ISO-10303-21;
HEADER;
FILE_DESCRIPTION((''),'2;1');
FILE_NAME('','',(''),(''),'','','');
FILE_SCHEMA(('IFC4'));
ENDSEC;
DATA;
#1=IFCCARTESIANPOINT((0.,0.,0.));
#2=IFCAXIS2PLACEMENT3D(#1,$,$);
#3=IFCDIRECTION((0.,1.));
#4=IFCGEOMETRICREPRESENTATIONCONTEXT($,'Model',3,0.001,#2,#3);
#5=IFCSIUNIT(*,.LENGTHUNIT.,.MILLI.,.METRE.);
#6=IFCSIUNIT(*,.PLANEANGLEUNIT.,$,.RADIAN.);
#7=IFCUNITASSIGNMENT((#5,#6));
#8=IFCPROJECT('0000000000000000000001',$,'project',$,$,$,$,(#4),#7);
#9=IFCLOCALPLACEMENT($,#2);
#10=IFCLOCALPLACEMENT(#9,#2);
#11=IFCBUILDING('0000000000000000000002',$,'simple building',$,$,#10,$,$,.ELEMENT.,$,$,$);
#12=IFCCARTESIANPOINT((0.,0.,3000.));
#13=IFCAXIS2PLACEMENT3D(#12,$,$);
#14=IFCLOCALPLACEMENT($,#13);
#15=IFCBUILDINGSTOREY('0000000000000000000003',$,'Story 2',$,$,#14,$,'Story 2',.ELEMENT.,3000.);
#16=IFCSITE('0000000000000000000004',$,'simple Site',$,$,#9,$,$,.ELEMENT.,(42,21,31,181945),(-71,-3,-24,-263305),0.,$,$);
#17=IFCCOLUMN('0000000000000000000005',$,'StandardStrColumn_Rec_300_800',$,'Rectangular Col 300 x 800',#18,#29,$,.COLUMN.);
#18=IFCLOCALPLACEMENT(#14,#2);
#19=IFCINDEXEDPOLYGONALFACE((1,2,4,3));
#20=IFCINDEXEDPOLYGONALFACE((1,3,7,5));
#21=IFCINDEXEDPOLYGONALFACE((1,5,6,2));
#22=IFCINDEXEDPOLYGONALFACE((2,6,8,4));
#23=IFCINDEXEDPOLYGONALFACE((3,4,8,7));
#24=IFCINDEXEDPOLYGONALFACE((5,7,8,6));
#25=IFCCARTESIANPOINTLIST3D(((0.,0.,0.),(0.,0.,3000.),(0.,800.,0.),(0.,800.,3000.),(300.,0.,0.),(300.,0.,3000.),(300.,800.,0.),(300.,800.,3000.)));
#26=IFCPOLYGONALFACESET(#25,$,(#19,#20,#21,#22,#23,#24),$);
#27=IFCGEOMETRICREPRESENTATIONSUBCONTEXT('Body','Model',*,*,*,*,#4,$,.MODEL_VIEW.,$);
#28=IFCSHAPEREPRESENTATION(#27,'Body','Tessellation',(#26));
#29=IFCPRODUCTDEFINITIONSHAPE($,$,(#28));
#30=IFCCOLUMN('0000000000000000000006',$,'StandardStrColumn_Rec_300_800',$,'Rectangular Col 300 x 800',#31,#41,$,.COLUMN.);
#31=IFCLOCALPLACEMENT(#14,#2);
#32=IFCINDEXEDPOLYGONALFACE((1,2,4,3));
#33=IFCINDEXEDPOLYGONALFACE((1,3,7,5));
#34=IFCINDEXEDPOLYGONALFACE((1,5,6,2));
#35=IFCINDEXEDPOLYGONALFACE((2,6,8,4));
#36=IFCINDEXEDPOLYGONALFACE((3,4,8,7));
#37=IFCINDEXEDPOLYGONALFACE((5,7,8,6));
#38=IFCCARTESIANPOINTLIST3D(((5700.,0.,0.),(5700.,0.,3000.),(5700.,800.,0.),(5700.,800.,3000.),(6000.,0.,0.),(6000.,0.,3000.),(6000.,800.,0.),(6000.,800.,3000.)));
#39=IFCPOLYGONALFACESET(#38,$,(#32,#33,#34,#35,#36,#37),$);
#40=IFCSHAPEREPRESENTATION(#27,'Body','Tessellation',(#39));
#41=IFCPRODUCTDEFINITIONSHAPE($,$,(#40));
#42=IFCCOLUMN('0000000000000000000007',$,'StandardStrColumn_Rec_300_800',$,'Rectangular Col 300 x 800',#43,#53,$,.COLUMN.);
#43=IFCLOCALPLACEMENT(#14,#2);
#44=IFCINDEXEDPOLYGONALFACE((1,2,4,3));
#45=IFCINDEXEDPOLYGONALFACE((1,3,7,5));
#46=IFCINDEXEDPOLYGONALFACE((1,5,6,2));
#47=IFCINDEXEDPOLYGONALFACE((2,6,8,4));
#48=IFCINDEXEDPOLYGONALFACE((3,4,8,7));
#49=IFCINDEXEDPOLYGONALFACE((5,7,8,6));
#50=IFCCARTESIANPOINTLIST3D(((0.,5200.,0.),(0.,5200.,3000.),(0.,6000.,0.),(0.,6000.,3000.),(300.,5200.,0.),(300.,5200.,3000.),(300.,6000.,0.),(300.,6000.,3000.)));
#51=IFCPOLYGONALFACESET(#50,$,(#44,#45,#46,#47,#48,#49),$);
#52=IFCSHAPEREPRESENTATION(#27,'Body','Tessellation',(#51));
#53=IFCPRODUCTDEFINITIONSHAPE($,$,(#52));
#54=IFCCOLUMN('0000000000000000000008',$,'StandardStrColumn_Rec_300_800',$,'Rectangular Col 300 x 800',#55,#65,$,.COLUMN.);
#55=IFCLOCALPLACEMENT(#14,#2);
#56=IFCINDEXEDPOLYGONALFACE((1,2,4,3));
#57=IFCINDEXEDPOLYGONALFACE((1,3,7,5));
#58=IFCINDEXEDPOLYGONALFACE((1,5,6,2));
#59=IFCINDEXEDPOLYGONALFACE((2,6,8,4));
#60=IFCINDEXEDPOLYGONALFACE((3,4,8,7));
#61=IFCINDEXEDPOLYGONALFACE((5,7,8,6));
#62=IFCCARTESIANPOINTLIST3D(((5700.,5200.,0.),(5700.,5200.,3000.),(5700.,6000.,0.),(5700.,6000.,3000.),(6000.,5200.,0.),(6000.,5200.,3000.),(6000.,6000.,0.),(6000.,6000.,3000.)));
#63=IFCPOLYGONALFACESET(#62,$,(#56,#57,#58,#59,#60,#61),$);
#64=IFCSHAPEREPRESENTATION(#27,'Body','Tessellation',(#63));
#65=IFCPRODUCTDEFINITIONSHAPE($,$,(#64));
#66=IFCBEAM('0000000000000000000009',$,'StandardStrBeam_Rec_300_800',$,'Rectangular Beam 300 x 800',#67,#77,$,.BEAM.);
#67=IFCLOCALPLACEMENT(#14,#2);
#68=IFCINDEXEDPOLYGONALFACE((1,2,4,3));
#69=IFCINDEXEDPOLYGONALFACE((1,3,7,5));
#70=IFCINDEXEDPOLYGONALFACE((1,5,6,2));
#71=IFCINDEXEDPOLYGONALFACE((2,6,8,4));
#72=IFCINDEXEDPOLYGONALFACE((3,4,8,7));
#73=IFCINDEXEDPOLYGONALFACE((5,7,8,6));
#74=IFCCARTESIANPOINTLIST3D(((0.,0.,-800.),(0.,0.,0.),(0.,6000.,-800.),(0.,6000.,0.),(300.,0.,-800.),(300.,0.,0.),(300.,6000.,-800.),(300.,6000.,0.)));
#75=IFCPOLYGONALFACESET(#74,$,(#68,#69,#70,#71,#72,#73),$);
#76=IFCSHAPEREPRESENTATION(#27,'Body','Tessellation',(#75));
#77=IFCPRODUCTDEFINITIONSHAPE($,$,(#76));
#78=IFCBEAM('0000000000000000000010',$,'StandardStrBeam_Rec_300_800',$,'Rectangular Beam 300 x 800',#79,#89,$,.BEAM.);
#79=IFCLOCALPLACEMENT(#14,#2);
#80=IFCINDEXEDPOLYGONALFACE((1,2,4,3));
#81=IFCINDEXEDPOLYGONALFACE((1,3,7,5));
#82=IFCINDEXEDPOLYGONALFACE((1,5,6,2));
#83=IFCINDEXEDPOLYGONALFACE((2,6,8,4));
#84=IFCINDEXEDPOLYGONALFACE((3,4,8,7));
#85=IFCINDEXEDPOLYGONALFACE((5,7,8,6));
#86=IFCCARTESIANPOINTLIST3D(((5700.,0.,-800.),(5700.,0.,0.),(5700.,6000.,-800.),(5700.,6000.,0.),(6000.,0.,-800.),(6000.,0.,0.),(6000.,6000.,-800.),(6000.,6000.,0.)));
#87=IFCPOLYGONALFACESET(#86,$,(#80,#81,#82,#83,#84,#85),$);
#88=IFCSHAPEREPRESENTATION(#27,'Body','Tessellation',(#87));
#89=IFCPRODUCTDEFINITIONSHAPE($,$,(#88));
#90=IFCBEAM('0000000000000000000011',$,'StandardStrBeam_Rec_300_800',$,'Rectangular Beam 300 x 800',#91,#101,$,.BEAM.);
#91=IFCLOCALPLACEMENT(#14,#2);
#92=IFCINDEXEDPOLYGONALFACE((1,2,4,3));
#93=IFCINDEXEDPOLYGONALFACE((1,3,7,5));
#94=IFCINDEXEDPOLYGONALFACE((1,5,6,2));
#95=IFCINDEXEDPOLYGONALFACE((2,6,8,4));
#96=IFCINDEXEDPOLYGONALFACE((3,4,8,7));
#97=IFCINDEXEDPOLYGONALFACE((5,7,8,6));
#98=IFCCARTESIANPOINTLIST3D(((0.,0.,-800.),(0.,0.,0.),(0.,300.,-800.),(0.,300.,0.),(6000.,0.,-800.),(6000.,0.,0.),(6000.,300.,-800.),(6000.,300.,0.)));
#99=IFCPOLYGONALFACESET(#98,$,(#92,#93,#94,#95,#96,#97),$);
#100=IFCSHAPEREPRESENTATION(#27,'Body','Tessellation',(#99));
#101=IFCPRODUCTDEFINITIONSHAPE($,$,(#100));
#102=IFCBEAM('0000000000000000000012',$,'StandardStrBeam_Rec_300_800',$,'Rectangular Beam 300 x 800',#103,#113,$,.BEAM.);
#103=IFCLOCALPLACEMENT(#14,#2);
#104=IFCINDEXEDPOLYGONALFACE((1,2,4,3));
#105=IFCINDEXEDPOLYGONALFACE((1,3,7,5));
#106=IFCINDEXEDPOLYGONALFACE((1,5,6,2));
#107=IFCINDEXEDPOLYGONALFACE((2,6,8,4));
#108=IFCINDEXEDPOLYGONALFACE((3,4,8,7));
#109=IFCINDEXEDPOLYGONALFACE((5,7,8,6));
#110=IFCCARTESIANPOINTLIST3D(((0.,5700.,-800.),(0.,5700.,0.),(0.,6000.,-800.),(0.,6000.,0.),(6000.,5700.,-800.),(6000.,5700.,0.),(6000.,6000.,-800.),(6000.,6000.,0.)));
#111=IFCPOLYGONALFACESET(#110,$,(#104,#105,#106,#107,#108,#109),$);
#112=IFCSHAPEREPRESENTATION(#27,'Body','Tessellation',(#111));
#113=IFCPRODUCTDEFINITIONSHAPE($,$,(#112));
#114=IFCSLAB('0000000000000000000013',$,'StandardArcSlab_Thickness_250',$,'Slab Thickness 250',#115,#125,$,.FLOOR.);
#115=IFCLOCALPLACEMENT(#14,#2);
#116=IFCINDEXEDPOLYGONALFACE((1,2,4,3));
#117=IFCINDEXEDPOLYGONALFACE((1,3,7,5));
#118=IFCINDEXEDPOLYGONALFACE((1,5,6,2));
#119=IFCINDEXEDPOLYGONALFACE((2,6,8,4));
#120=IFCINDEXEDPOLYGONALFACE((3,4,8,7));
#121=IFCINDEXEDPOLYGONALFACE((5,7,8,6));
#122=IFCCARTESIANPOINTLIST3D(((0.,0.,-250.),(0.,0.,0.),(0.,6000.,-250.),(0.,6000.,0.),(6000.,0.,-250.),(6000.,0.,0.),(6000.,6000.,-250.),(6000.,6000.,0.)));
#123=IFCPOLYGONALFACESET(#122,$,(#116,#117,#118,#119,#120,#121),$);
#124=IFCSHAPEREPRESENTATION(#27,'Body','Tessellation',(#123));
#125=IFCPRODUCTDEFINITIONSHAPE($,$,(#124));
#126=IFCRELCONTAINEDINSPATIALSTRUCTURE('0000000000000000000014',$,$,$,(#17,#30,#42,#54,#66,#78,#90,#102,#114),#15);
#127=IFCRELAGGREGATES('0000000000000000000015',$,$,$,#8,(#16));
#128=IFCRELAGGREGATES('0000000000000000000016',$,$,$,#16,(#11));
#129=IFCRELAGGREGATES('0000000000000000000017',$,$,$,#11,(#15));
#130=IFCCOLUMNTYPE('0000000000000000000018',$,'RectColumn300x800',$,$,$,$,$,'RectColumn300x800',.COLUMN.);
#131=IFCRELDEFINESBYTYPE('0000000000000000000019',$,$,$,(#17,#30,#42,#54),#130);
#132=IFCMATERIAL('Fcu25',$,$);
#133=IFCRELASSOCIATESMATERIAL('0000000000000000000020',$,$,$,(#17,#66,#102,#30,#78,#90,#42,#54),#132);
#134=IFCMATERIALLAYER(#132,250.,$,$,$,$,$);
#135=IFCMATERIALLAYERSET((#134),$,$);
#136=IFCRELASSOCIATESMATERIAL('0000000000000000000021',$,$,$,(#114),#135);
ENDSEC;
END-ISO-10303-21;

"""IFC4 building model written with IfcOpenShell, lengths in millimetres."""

from ifc_helpers import new_model, si_unit, direction, frame, origin, origin_with_axes, origin_2d_with_axis, place, context, subcontext, project, spatial, polyline, rectangle, outline, extrude, material, layer, layer_set, layer_usage, material_profile, profile_set, profile_usage, type_object, element, save


model = new_model("IFC4")

# Units and contexts
model_context = context("Model", 3, precision=0.001, world=origin(), true_north=direction((0.0, 1.0)))
body_context = subcontext(model_context, "Body", "Model", "MODEL_VIEW")
ifc_project = project(units=[si_unit("LENGTHUNIT", "METRE", prefix="MILLI"), si_unit("PLANEANGLEUNIT", "RADIAN")], contexts=[model_context])

# Site, building, storey
site_placement = place(None, origin())
site = spatial("IfcSite", under=ifc_project, at=site_placement, Name="simple Site", CompositionType="ELEMENT", RefLatitude=(42, 21, 31, 181945), RefLongitude=(-71, -3, -24, -263305), RefElevation=0.0)
building_placement = place(site_placement, origin())
building = spatial("IfcBuilding", under=site, at=building_placement, Name="simple building", CompositionType="ELEMENT")
storey_placement = place(None, frame((0.0, 0.0, 3000.0)))
storey = spatial("IfcBuildingStorey", under=building, at=storey_placement, Name="Story 2", LongName="Story 2", CompositionType="ELEMENT", Elevation=3000.0)

# Columns
ifc_material = material(Name="Fcu25")
ifc_material_profile = material_profile(ifc_material, rectangle(XDim=300.0, YDim=800.0, at=origin_2d_with_axis()))
ifc_profile_set = profile_set([ifc_material_profile])
ifc_profile_usage_1 = profile_usage(ifc_profile_set, cardinal=7)
column_type = type_object("IfcColumnType", Name="RectColumn300x800", ElementType="RectColumn300x800", PredefinedType="COLUMN")
column_1_placement = place(None, frame((150.0, 400.0, 3000.0), z_axis=(0.0, 0.0, 1.0), x_axis=(1.0, 0.0, 0.0)))
element("IfcColumn", 1, at=column_1_placement, inside=storey, type_object=column_type, material=ifc_profile_usage_1, Name="StandardStrColumn_Rec_300_800", ObjectType="Rectangular Col 300 x 800", PredefinedType="COLUMN", context=body_context, shape_type="SweptSolid", body=[
    extrude(rectangle(XDim=300.0, YDim=800.0, at=origin_2d_with_axis()), origin_with_axes(), (0.0, 0.0, 1.0), 3000.0),
])
ifc_profile_usage_2 = profile_usage(ifc_profile_set, cardinal=9)
column_2_placement = place(None, frame((5850.0, 400.0, 3000.0), z_axis=(0.0, 0.0, 1.0), x_axis=(1.0, 0.0, 0.0)))
element("IfcColumn", 2, at=column_2_placement, inside=storey, type_object=column_type, material=ifc_profile_usage_2, Name="StandardStrColumn_Rec_300_800", ObjectType="Rectangular Col 300 x 800", PredefinedType="COLUMN", context=body_context, shape_type="SweptSolid", body=[
    extrude(rectangle(XDim=300.0, YDim=800.0, at=origin_2d_with_axis()), origin_with_axes(), (0.0, 0.0, 1.0), 3000.0),
])
ifc_profile_usage_3 = profile_usage(ifc_profile_set, cardinal=1)
column_3_placement = place(None, frame((150.0, 5600.0, 3000.0), z_axis=(0.0, 0.0, 1.0), x_axis=(1.0, 0.0, 0.0)))
element("IfcColumn", 3, at=column_3_placement, inside=storey, type_object=column_type, material=ifc_profile_usage_3, Name="StandardStrColumn_Rec_300_800", ObjectType="Rectangular Col 300 x 800", PredefinedType="COLUMN", context=body_context, shape_type="SweptSolid", body=[
    extrude(rectangle(XDim=300.0, YDim=800.0, at=origin_2d_with_axis()), origin_with_axes(), (0.0, 0.0, 1.0), 3000.0),
])
ifc_profile_usage_4 = profile_usage(ifc_profile_set, cardinal=3)
column_4_placement = place(None, frame((5850.0, 5600.0, 3000.0), z_axis=(0.0, 0.0, 1.0), x_axis=(1.0, 0.0, 0.0)))
element("IfcColumn", 4, at=column_4_placement, inside=storey, type_object=column_type, material=ifc_profile_usage_4, Name="StandardStrColumn_Rec_300_800", ObjectType="Rectangular Col 300 x 800", PredefinedType="COLUMN", context=body_context, shape_type="SweptSolid", body=[
    extrude(rectangle(XDim=300.0, YDim=800.0, at=origin_2d_with_axis()), origin_with_axes(), (0.0, 0.0, 1.0), 3000.0),
])

# Beams
beam_1_placement = place(None, frame((150.0, 0.0, 2600.0), z_axis=(0.0, 1.0, 0.0), x_axis=(1.0, 0.0, 0.0)))
element("IfcBeam", 5, at=beam_1_placement, inside=storey, material=ifc_profile_usage_1, Name="StandardStrBeam_Rec_300_800", ObjectType="Rectangular Beam 300 x 800", PredefinedType="BEAM", context=body_context, shape_type="SweptSolid", body=[
    extrude(rectangle(XDim=300.0, YDim=800.0, at=origin_2d_with_axis()), origin_with_axes(), (0.0, 0.0, 1.0), 6000.0),
])
for number, where, z_axis, x_axis, name in (
    (6, (5850.0, 0.0, 2600.0), (0.0, 1.0, 0.0), (1.0, 0.0, 0.0), "StandardStrBeam_Rec_300_800"),
    (7, (0.0, 150.0, 2600.0), (1.0, 0.0, 0.0), (0.0, -1.0, 0.0), "StandardStrBeam_Rec_300_800"),
):
    element("IfcBeam", number, at=place(None, frame(where, z_axis=z_axis, x_axis=x_axis)), inside=storey, material=ifc_profile_usage_2, Name=name, ObjectType="Rectangular Beam 300 x 800", PredefinedType="BEAM", context=body_context, shape_type="SweptSolid", body=[
        extrude(rectangle(XDim=300.0, YDim=800.0, at=origin_2d_with_axis()), origin_with_axes(), (0.0, 0.0, 1.0), 6000.0),
    ])
beam_2_placement = place(None, frame((0.0, 5850.0, 2600.0), z_axis=(1.0, 0.0, 0.0), x_axis=(0.0, -1.0, 0.0)))
element("IfcBeam", 8, at=beam_2_placement, inside=storey, material=ifc_profile_usage_1, Name="StandardStrBeam_Rec_300_800", ObjectType="Rectangular Beam 300 x 800", PredefinedType="BEAM", context=body_context, shape_type="SweptSolid", body=[
    extrude(rectangle(XDim=300.0, YDim=800.0, at=origin_2d_with_axis()), origin_with_axes(), (0.0, 0.0, 1.0), 6000.0),
])

# Slab
ifc_layer = layer(ifc_material, 250.0)
ifc_layer_set = layer_set([ifc_layer])
ifc_layer_usage = layer_usage(ifc_layer_set, "AXIS3", "POSITIVE", -250.0)
slab_placement = place(None, frame((0.0, 0.0, 2750.0), z_axis=(0.0, 0.0, 1.0), x_axis=(1.0, 0.0, 0.0)))
element("IfcSlab", 9, at=slab_placement, inside=storey, material=ifc_layer_usage, Name="StandardArcSlab_Thickness_250", ObjectType="Slab Thickness 250", PredefinedType="FLOOR", context=body_context, shape_type="SweptSolid", body=[
    extrude(outline(polyline([(0.0, 0.0), (6000.0, 0.0), (6000.0, 6000.0), (0.0, 6000.0), (0.0, 0.0)])), origin_with_axes(), (0.0, 0.0, 1.0), 250.0),
])

save(model, "model.ifc")
